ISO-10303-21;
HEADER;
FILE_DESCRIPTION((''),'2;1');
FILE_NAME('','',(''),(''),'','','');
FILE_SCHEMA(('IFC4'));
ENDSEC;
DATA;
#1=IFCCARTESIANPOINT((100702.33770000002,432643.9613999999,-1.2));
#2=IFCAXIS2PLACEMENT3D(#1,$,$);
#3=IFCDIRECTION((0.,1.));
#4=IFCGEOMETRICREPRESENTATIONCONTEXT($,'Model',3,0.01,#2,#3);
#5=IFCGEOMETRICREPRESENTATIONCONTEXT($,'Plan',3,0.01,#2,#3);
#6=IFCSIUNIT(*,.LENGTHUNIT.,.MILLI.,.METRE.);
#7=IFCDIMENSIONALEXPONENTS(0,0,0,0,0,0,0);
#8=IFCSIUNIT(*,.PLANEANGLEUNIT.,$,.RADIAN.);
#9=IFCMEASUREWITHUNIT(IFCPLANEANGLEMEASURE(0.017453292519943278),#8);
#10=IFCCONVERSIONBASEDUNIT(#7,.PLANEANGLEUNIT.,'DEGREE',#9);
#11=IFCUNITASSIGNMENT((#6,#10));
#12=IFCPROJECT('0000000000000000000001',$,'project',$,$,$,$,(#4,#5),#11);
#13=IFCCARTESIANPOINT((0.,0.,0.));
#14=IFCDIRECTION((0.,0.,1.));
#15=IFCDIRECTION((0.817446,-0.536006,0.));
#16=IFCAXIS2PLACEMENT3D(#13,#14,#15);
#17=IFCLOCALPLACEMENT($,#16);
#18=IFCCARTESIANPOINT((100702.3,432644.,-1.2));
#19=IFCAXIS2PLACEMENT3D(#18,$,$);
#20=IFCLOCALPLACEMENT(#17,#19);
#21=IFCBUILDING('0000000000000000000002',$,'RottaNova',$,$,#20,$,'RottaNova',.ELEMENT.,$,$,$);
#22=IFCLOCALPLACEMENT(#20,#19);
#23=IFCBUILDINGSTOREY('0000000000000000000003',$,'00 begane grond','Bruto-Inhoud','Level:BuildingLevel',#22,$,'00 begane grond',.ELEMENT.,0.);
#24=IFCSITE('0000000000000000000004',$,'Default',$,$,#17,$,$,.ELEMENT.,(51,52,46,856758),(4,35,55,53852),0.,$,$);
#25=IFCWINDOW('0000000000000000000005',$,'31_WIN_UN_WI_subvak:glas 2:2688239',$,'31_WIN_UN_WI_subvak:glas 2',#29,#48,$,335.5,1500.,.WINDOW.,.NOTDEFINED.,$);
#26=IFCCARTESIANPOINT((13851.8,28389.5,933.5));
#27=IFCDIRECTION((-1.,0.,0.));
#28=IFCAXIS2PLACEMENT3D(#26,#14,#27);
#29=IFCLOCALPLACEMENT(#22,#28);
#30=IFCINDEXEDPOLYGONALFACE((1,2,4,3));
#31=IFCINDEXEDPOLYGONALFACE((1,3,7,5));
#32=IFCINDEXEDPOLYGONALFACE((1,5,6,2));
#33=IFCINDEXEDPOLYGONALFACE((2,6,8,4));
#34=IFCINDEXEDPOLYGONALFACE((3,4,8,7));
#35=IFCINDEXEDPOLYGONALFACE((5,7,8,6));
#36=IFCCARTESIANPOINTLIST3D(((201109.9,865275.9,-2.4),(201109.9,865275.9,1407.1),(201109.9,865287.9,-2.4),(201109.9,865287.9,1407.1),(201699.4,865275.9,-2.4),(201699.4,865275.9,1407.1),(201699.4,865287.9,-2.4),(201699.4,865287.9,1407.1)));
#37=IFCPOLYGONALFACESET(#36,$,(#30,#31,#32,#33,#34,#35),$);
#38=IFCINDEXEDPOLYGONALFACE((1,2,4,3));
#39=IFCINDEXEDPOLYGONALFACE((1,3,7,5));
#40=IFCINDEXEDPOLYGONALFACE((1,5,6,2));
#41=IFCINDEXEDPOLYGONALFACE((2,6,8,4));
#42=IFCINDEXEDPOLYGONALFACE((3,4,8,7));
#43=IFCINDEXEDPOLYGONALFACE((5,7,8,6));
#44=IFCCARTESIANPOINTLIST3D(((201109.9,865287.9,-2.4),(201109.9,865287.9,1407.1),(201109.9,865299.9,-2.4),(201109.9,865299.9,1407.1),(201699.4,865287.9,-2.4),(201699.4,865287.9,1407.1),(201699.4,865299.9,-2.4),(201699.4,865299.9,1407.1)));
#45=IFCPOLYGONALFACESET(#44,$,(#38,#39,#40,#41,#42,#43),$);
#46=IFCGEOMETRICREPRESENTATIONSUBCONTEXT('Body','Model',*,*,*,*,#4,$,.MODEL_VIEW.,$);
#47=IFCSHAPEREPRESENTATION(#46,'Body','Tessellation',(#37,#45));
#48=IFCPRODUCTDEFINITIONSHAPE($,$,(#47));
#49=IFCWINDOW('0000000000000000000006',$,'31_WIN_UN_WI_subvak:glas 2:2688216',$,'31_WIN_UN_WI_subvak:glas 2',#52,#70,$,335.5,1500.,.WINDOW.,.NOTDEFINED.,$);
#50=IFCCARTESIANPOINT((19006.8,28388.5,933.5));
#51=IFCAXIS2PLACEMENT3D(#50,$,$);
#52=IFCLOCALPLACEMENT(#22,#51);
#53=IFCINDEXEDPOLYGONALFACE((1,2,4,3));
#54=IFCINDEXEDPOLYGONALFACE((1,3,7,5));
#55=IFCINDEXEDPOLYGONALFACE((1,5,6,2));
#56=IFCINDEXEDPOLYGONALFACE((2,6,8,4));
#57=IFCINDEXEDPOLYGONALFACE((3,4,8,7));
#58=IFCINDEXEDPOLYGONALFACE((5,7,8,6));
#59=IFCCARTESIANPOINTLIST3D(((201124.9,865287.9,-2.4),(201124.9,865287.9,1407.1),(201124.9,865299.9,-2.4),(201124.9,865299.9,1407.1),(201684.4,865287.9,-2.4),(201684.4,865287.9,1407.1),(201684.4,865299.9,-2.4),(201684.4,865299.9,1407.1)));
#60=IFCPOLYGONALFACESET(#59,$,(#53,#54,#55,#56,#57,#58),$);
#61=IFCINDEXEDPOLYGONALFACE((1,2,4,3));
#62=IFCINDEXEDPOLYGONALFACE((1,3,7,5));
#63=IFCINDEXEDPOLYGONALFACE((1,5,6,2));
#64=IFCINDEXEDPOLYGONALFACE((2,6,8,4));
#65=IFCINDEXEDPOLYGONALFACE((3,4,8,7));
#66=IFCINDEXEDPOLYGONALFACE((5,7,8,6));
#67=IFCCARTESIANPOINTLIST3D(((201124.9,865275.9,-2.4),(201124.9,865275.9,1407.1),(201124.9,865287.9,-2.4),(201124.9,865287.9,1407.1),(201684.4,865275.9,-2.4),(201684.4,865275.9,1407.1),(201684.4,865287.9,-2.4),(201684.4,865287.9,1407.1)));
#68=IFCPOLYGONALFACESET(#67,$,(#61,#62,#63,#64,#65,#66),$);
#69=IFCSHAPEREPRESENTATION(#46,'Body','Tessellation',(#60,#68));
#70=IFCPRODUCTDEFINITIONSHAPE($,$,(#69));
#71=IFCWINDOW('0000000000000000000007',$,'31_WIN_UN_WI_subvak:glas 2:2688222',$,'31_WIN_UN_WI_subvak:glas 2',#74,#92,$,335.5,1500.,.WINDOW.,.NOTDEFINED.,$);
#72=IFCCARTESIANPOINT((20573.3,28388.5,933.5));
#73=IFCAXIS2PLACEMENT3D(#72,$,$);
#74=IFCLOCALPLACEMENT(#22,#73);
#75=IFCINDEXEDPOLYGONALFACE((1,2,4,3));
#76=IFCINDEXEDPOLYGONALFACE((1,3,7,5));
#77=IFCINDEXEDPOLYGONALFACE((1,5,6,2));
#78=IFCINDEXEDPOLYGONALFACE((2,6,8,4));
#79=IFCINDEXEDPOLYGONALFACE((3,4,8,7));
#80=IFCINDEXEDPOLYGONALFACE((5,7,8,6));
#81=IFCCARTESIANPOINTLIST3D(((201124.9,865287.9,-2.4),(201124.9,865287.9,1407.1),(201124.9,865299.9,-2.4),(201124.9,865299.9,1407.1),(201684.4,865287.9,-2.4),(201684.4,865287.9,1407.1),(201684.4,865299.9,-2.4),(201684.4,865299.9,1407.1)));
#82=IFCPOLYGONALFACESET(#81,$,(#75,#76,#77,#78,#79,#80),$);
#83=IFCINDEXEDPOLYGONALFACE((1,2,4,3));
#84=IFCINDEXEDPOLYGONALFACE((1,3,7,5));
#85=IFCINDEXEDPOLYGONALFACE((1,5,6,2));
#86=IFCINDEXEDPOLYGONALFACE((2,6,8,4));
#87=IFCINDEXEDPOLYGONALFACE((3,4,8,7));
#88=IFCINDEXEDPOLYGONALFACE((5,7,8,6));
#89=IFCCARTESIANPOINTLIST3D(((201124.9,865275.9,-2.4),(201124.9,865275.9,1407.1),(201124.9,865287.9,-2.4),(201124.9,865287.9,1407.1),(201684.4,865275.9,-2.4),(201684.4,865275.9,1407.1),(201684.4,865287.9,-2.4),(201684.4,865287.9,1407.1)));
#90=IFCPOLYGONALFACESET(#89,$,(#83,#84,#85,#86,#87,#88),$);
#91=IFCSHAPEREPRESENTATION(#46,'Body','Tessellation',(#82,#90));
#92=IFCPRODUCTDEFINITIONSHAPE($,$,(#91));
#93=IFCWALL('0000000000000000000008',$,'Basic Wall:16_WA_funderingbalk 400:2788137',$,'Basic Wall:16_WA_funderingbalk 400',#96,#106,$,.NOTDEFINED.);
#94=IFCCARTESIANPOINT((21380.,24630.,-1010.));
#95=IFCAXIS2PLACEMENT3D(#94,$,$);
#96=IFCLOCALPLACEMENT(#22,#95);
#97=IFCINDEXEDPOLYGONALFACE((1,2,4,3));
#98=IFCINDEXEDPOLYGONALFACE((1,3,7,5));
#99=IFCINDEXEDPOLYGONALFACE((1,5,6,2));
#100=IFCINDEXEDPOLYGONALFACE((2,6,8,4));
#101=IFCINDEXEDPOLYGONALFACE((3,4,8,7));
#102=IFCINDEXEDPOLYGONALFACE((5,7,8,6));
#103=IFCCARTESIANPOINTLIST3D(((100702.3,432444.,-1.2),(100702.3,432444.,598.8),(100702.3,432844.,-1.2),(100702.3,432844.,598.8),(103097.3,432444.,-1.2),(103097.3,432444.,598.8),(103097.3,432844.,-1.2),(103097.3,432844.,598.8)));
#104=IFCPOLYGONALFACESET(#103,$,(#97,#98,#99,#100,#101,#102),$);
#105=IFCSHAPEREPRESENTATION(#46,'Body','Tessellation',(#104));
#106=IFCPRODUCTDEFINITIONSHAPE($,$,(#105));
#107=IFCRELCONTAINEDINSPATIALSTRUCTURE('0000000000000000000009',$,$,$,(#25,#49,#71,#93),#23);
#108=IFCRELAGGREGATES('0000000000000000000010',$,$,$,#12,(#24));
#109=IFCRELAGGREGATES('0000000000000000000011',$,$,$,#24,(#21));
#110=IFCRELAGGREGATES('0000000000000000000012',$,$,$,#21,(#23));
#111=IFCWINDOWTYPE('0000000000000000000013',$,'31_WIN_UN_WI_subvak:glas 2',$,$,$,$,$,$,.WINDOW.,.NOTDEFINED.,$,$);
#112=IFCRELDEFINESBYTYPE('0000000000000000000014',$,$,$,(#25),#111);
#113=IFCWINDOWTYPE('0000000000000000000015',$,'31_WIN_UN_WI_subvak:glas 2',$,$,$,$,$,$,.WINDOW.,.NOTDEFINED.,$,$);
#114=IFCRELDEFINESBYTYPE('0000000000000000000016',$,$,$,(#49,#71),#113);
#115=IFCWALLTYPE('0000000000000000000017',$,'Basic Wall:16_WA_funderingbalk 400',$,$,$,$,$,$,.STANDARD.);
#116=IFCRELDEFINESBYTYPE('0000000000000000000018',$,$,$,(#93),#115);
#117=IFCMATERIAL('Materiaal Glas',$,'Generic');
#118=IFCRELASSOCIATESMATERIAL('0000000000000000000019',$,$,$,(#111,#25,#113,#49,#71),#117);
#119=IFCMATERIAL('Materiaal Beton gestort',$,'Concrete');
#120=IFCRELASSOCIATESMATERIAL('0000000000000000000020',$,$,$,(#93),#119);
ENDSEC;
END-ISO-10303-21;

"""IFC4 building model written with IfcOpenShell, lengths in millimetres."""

from ifc_helpers import new_model, entity, si_unit, converted_unit, direction, frame, place, context, subcontext, project, spatial, indexed_curve, outline, extrude, source, transform, mapped, material, type_object, type_shapes, element, save


model = new_model("IFC4")

# Units and contexts
model_context = context("Model", 3, precision=0.01, world=frame((100702.33770000002, 432643.9613999999, -1.2)), true_north=direction((0.0, 1.0)))
plan_context = context("Plan", 3, precision=0.01, world=frame((100702.33770000002, 432643.9613999999, -1.2)), true_north=direction((0.0, 1.0)))
body_context = subcontext(model_context, "Body", "Model", "MODEL_VIEW")
ifc_project = project(units=[si_unit("LENGTHUNIT", "METRE", prefix="MILLI"), converted_unit("PLANEANGLEUNIT", "DEGREE", entity("IfcPlaneAngleMeasure", 0.017453292519943278), si_unit("PLANEANGLEUNIT", "RADIAN"), dimensions=[0, 0, 0, 0, 0, 0, 0])], contexts=[model_context, plan_context])

# Site, building, storey
site_placement = place(None, frame((0.0, 0.0, 0.0), z_axis=(0.0, 0.0, 1.0), x_axis=(0.817446, -0.536006, 0.0)))
site = spatial("IfcSite", under=ifc_project, at=site_placement, Name="Default", CompositionType="ELEMENT", RefLatitude=(51, 52, 46, 856758), RefLongitude=(4, 35, 55, 53852), RefElevation=0.0)
building_placement = place(site_placement, frame((100702.3, 432644.0, -1.2)))
building = spatial("IfcBuilding", under=site, at=building_placement, Name="RottaNova", LongName="RottaNova", CompositionType="ELEMENT")
storey_placement = place(building_placement, frame((100702.3, 432644.0, -1.2)))
storey = spatial("IfcBuildingStorey", under=building, at=storey_placement, Name="00 begane grond", Description="Bruto-Inhoud", ObjectType="Level:BuildingLevel", LongName="00 begane grond", CompositionType="ELEMENT", Elevation=0.0)

# Windows
ifc_material_1 = material(Name="Materiaal Glas", Category="Generic")
window_type_1 = type_object("IfcWindowType", Name="31_WIN_UN_WI_subvak:glas 2", PartitioningType="NOTDEFINED", PredefinedType="WINDOW", material=ifc_material_1)
shared_shape_1 = source(frame((100702.3, 432644.0, -1.2)), body_context, "Body", "SweptSolid", [
    extrude(outline(indexed_curve([(-294.7, -6.0), (294.7, -6.0), (294.7, 6.0), (-294.7, 6.0), (-294.7, -6.0)], self_intersect=False)), frame((0.0, -6.0, 0.0)), (0.0, 0.0, 1.0), 1409.5),
    extrude(outline(indexed_curve([(-294.8, -6.0), (294.8, -6.0), (294.8, 6.0), (-294.8, 6.0), (-294.8, -6.0)], self_intersect=False)), frame((0.0, 6.0, 0.0)), (0.0, 0.0, 1.0), 1409.5),
])
type_shapes(window_type_1, [shared_shape_1])
for number, where, z_axis, x_axis, name in (
    (1, (13851.8, 28389.5, 933.5), (0.0, 0.0, 1.0), (-1.0, 0.0, 0.0), "31_WIN_UN_WI_subvak:glas 2:2688239"),
):
    element("IfcWindow", number, at=place(storey_placement, frame(where, z_axis=z_axis, x_axis=x_axis)), inside=storey, type_object=window_type_1, material=ifc_material_1, Name=name, ObjectType="31_WIN_UN_WI_subvak:glas 2", OverallHeight=335.5, OverallWidth=1500.0, PartitioningType="NOTDEFINED", PredefinedType="WINDOW", context=body_context, shape_type="MappedRepresentation", body=[
        mapped(shared_shape_1, transform((100702.3, 432644.0, -1.2), scale=1.0)),
    ])
window_type_2 = type_object("IfcWindowType", Name="31_WIN_UN_WI_subvak:glas 2", PartitioningType="NOTDEFINED", PredefinedType="WINDOW", material=ifc_material_1)
shared_shape_2 = source(frame((100702.3, 432644.0, -1.2)), body_context, "Body", "SweptSolid", [
    extrude(outline(indexed_curve([(-6.0, -279.8), (6.0, -279.8), (6.0, 279.8), (-6.0, 279.8), (-6.0, -279.8)], self_intersect=False)), frame((0.0, 6.0, 0.0), z_axis=(0.0, 0.0, 1.0), x_axis=(0.0, -1.0, 0.0)), (0.0, 0.0, 1.0), 1409.5),
    extrude(outline(indexed_curve([(-6.0, -279.8), (6.0, -279.8), (6.0, 279.8), (-6.0, 279.8), (-6.0, -279.8)], self_intersect=False)), frame((0.0, -6.0, 0.0), z_axis=(0.0, 0.0, 1.0), x_axis=(0.0, -1.0, 0.0)), (0.0, 0.0, 1.0), 1409.5),
])
type_shapes(window_type_2, [shared_shape_2])
for number, where, name in (
    (2, (19006.8, 28388.5, 933.5), "31_WIN_UN_WI_subvak:glas 2:2688216"),
    (3, (20573.3, 28388.5, 933.5), "31_WIN_UN_WI_subvak:glas 2:2688222"),
):
    element("IfcWindow", number, at=place(storey_placement, frame(where)), inside=storey, type_object=window_type_2, material=ifc_material_1, Name=name, ObjectType="31_WIN_UN_WI_subvak:glas 2", OverallHeight=335.5, OverallWidth=1500.0, PartitioningType="NOTDEFINED", PredefinedType="WINDOW", context=body_context, shape_type="MappedRepresentation", body=[
        mapped(shared_shape_2, transform((100702.3, 432644.0, -1.2), scale=1.0)),
    ])

# Wall
ifc_material_2 = material(Name="Materiaal Beton gestort", Category="Concrete")
wall_type_1 = type_object("IfcWallType", Name="Basic Wall:16_WA_funderingbalk 400", PredefinedType="STANDARD")
wall_1_placement = place(storey_placement, frame((21380.0, 24630.0, -1010.0)))
element("IfcWall", 4, at=wall_1_placement, inside=storey, type_object=wall_type_1, material=ifc_material_2, Name="Basic Wall:16_WA_funderingbalk 400:2788137", ObjectType="Basic Wall:16_WA_funderingbalk 400", PredefinedType="NOTDEFINED", context=body_context, shape_type="SweptSolid", body=[
    extrude(outline(indexed_curve([(2395.0, 200.0), (0.0, 200.0), (0.0, -200.0), (2395.0, -200.0), (2395.0, 200.0)], self_intersect=False)), frame((100702.3, 432644.0, -1.2)), (0.0, 0.0, 1.0), 600.0),
])

save(model, "model.ifc")
